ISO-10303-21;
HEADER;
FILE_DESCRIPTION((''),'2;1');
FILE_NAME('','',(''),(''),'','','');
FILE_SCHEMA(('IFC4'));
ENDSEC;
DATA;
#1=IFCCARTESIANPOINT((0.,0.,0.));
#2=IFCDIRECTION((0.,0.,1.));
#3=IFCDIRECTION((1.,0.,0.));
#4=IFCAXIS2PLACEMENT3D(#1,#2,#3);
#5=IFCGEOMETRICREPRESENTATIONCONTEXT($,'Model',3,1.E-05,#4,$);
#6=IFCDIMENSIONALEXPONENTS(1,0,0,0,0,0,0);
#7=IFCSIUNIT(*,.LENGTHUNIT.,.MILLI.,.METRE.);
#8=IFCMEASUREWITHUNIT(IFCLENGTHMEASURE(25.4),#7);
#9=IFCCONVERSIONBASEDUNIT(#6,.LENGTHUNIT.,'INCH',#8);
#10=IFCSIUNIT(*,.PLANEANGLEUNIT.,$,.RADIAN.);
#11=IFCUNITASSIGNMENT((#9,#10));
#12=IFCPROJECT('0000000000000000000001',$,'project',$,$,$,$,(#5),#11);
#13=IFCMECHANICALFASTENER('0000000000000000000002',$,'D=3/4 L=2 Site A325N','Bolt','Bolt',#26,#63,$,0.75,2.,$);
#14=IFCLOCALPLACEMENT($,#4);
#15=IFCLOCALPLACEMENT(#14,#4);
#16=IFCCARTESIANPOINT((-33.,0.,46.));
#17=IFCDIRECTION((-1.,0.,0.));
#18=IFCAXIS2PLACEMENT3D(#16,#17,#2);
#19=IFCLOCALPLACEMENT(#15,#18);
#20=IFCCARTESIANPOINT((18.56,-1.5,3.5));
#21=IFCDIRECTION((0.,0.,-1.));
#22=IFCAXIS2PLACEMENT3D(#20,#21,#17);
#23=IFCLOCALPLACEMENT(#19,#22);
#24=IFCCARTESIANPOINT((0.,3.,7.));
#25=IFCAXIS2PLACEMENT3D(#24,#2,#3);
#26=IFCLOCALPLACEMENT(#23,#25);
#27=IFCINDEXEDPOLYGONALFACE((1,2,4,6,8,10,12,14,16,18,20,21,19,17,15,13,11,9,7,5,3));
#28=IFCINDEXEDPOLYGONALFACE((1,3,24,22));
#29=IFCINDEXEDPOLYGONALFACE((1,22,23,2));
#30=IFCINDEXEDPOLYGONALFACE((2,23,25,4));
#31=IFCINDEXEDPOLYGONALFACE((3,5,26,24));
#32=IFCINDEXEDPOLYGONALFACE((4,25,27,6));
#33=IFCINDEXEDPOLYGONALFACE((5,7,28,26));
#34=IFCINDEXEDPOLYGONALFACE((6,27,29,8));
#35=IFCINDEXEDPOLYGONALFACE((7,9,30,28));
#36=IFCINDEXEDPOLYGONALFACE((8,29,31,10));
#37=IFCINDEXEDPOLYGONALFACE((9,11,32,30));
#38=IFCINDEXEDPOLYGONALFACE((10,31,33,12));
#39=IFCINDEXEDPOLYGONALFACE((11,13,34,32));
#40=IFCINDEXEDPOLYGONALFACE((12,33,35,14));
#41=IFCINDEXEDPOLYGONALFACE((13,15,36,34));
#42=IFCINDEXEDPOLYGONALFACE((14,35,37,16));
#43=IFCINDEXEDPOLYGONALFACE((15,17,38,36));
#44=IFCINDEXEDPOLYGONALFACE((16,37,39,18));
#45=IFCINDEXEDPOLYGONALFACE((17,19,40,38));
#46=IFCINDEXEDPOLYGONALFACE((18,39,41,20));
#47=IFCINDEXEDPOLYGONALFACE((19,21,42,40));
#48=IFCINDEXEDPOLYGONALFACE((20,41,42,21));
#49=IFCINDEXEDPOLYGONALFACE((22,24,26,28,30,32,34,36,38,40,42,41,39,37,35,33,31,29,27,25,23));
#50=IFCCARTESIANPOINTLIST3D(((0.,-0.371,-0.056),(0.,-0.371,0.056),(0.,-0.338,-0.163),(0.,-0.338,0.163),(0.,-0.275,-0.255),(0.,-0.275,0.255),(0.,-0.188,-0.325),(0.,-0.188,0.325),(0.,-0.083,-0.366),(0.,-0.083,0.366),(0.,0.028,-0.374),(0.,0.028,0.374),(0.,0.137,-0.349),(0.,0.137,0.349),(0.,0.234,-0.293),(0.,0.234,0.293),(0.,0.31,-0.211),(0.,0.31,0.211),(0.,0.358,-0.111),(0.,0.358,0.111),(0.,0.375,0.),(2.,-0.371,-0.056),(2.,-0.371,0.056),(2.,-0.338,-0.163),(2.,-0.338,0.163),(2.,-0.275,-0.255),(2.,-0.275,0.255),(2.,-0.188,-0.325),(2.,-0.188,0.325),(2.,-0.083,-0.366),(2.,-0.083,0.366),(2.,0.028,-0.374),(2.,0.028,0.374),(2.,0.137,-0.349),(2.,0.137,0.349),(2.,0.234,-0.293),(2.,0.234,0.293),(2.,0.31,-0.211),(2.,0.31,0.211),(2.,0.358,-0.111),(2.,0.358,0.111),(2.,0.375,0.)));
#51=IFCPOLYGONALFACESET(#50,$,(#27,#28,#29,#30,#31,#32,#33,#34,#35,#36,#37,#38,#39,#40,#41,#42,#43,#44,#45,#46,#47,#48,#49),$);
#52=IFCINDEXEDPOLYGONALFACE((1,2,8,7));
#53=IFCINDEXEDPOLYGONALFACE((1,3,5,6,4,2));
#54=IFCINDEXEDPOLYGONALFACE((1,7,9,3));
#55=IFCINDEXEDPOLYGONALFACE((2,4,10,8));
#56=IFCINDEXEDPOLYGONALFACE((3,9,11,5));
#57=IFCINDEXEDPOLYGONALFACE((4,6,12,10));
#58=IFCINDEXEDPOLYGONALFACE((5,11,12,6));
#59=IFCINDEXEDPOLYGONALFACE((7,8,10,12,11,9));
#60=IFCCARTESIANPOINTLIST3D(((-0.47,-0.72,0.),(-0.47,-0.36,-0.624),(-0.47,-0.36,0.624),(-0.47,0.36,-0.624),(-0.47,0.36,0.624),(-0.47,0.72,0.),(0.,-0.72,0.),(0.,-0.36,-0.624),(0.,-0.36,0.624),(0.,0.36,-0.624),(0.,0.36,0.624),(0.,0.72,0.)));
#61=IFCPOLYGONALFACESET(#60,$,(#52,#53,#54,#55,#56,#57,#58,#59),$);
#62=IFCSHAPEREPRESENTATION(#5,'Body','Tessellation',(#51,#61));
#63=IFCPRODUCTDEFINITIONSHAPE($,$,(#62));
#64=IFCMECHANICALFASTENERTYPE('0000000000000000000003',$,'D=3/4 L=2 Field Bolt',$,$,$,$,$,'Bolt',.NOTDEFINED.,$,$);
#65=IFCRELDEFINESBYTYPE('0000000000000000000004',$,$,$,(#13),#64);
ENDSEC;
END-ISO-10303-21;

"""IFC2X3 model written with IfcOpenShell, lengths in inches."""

from ifc_helpers import new_model, entity, si_unit, converted_unit, frame, origin_with_axes, origin_2d_with_axis, place, context, project, polyline, circle, outline, extrude, source, transform, mapped, type_object, type_shapes, element, save


model = new_model("IFC2X3")

# Units and contexts
model_context = context("Model", 3, precision=1e-05, world=origin_with_axes())
ifc_project = project(units=[converted_unit("LENGTHUNIT", "INCH", entity("IfcLengthMeasure", 25.4), si_unit("LENGTHUNIT", "METRE", prefix="MILLI"), dimensions=[1, 0, 0, 0, 0, 0, 0]), si_unit("PLANEANGLEUNIT", "RADIAN")], contexts=[model_context])

# Mechanical fastener
placement_1 = place(None, origin_with_axes())
placement_2 = place(placement_1, origin_with_axes())
mechanical_fastener_type_1 = type_object("IfcMechanicalFastenerType", Name="D=3/4 L=2 Field Bolt", ElementType="Bolt")
shared_shape_1 = source(origin_with_axes(), model_context, "Body", "SweptSolid", [
    extrude(circle(Radius=0.375, at=origin_2d_with_axis()), frame((0.0, 0.0, 0.0), z_axis=(1.0, 0.0, 0.0), x_axis=(0.0, 1.0, 0.0)), (0.0, 0.0, 1.0), 2.0),
    extrude(outline(polyline([(-0.72, 0.0), (-0.36, 0.624), (0.36, 0.624), (0.72, 0.0), (0.36, -0.624), (-0.36, -0.624), (-0.72, 0.0)])), frame((0.0, 0.0, 0.0), z_axis=(1.0, 0.0, 0.0), x_axis=(0.0, 1.0, 0.0)), (0.0, 0.0, -1.0), 0.47),
])
type_shapes(mechanical_fastener_type_1, [shared_shape_1])
placement_3 = place(placement_2, frame((-33.0, 0.0, 46.0), z_axis=(-1.0, 0.0, 0.0), x_axis=(0.0, 0.0, 1.0)))
placement_4 = place(placement_3, frame((18.56, -1.5, 3.5), z_axis=(0.0, 0.0, -1.0), x_axis=(-1.0, 0.0, 0.0)))
for number, where, z_axis, x_axis, name in (
    (1, (0.0, 3.0, 7.0), (0.0, 0.0, 1.0), (1.0, 0.0, 0.0), "D=3/4 L=2 Site A325N"),
):
    element("IfcMechanicalFastener", number, at=place(placement_4, frame(where, z_axis=z_axis, x_axis=x_axis)), type_object=mechanical_fastener_type_1, Name=name, Description="Bolt", ObjectType="Bolt", NominalDiameter=0.75, NominalLength=2.0, context=model_context, shape_type="MappedRepresentation", body=[
        mapped(shared_shape_1, transform((0.0, 0.0, 0.0), scale=1.0)),
    ])

save(model, "model.ifc")
